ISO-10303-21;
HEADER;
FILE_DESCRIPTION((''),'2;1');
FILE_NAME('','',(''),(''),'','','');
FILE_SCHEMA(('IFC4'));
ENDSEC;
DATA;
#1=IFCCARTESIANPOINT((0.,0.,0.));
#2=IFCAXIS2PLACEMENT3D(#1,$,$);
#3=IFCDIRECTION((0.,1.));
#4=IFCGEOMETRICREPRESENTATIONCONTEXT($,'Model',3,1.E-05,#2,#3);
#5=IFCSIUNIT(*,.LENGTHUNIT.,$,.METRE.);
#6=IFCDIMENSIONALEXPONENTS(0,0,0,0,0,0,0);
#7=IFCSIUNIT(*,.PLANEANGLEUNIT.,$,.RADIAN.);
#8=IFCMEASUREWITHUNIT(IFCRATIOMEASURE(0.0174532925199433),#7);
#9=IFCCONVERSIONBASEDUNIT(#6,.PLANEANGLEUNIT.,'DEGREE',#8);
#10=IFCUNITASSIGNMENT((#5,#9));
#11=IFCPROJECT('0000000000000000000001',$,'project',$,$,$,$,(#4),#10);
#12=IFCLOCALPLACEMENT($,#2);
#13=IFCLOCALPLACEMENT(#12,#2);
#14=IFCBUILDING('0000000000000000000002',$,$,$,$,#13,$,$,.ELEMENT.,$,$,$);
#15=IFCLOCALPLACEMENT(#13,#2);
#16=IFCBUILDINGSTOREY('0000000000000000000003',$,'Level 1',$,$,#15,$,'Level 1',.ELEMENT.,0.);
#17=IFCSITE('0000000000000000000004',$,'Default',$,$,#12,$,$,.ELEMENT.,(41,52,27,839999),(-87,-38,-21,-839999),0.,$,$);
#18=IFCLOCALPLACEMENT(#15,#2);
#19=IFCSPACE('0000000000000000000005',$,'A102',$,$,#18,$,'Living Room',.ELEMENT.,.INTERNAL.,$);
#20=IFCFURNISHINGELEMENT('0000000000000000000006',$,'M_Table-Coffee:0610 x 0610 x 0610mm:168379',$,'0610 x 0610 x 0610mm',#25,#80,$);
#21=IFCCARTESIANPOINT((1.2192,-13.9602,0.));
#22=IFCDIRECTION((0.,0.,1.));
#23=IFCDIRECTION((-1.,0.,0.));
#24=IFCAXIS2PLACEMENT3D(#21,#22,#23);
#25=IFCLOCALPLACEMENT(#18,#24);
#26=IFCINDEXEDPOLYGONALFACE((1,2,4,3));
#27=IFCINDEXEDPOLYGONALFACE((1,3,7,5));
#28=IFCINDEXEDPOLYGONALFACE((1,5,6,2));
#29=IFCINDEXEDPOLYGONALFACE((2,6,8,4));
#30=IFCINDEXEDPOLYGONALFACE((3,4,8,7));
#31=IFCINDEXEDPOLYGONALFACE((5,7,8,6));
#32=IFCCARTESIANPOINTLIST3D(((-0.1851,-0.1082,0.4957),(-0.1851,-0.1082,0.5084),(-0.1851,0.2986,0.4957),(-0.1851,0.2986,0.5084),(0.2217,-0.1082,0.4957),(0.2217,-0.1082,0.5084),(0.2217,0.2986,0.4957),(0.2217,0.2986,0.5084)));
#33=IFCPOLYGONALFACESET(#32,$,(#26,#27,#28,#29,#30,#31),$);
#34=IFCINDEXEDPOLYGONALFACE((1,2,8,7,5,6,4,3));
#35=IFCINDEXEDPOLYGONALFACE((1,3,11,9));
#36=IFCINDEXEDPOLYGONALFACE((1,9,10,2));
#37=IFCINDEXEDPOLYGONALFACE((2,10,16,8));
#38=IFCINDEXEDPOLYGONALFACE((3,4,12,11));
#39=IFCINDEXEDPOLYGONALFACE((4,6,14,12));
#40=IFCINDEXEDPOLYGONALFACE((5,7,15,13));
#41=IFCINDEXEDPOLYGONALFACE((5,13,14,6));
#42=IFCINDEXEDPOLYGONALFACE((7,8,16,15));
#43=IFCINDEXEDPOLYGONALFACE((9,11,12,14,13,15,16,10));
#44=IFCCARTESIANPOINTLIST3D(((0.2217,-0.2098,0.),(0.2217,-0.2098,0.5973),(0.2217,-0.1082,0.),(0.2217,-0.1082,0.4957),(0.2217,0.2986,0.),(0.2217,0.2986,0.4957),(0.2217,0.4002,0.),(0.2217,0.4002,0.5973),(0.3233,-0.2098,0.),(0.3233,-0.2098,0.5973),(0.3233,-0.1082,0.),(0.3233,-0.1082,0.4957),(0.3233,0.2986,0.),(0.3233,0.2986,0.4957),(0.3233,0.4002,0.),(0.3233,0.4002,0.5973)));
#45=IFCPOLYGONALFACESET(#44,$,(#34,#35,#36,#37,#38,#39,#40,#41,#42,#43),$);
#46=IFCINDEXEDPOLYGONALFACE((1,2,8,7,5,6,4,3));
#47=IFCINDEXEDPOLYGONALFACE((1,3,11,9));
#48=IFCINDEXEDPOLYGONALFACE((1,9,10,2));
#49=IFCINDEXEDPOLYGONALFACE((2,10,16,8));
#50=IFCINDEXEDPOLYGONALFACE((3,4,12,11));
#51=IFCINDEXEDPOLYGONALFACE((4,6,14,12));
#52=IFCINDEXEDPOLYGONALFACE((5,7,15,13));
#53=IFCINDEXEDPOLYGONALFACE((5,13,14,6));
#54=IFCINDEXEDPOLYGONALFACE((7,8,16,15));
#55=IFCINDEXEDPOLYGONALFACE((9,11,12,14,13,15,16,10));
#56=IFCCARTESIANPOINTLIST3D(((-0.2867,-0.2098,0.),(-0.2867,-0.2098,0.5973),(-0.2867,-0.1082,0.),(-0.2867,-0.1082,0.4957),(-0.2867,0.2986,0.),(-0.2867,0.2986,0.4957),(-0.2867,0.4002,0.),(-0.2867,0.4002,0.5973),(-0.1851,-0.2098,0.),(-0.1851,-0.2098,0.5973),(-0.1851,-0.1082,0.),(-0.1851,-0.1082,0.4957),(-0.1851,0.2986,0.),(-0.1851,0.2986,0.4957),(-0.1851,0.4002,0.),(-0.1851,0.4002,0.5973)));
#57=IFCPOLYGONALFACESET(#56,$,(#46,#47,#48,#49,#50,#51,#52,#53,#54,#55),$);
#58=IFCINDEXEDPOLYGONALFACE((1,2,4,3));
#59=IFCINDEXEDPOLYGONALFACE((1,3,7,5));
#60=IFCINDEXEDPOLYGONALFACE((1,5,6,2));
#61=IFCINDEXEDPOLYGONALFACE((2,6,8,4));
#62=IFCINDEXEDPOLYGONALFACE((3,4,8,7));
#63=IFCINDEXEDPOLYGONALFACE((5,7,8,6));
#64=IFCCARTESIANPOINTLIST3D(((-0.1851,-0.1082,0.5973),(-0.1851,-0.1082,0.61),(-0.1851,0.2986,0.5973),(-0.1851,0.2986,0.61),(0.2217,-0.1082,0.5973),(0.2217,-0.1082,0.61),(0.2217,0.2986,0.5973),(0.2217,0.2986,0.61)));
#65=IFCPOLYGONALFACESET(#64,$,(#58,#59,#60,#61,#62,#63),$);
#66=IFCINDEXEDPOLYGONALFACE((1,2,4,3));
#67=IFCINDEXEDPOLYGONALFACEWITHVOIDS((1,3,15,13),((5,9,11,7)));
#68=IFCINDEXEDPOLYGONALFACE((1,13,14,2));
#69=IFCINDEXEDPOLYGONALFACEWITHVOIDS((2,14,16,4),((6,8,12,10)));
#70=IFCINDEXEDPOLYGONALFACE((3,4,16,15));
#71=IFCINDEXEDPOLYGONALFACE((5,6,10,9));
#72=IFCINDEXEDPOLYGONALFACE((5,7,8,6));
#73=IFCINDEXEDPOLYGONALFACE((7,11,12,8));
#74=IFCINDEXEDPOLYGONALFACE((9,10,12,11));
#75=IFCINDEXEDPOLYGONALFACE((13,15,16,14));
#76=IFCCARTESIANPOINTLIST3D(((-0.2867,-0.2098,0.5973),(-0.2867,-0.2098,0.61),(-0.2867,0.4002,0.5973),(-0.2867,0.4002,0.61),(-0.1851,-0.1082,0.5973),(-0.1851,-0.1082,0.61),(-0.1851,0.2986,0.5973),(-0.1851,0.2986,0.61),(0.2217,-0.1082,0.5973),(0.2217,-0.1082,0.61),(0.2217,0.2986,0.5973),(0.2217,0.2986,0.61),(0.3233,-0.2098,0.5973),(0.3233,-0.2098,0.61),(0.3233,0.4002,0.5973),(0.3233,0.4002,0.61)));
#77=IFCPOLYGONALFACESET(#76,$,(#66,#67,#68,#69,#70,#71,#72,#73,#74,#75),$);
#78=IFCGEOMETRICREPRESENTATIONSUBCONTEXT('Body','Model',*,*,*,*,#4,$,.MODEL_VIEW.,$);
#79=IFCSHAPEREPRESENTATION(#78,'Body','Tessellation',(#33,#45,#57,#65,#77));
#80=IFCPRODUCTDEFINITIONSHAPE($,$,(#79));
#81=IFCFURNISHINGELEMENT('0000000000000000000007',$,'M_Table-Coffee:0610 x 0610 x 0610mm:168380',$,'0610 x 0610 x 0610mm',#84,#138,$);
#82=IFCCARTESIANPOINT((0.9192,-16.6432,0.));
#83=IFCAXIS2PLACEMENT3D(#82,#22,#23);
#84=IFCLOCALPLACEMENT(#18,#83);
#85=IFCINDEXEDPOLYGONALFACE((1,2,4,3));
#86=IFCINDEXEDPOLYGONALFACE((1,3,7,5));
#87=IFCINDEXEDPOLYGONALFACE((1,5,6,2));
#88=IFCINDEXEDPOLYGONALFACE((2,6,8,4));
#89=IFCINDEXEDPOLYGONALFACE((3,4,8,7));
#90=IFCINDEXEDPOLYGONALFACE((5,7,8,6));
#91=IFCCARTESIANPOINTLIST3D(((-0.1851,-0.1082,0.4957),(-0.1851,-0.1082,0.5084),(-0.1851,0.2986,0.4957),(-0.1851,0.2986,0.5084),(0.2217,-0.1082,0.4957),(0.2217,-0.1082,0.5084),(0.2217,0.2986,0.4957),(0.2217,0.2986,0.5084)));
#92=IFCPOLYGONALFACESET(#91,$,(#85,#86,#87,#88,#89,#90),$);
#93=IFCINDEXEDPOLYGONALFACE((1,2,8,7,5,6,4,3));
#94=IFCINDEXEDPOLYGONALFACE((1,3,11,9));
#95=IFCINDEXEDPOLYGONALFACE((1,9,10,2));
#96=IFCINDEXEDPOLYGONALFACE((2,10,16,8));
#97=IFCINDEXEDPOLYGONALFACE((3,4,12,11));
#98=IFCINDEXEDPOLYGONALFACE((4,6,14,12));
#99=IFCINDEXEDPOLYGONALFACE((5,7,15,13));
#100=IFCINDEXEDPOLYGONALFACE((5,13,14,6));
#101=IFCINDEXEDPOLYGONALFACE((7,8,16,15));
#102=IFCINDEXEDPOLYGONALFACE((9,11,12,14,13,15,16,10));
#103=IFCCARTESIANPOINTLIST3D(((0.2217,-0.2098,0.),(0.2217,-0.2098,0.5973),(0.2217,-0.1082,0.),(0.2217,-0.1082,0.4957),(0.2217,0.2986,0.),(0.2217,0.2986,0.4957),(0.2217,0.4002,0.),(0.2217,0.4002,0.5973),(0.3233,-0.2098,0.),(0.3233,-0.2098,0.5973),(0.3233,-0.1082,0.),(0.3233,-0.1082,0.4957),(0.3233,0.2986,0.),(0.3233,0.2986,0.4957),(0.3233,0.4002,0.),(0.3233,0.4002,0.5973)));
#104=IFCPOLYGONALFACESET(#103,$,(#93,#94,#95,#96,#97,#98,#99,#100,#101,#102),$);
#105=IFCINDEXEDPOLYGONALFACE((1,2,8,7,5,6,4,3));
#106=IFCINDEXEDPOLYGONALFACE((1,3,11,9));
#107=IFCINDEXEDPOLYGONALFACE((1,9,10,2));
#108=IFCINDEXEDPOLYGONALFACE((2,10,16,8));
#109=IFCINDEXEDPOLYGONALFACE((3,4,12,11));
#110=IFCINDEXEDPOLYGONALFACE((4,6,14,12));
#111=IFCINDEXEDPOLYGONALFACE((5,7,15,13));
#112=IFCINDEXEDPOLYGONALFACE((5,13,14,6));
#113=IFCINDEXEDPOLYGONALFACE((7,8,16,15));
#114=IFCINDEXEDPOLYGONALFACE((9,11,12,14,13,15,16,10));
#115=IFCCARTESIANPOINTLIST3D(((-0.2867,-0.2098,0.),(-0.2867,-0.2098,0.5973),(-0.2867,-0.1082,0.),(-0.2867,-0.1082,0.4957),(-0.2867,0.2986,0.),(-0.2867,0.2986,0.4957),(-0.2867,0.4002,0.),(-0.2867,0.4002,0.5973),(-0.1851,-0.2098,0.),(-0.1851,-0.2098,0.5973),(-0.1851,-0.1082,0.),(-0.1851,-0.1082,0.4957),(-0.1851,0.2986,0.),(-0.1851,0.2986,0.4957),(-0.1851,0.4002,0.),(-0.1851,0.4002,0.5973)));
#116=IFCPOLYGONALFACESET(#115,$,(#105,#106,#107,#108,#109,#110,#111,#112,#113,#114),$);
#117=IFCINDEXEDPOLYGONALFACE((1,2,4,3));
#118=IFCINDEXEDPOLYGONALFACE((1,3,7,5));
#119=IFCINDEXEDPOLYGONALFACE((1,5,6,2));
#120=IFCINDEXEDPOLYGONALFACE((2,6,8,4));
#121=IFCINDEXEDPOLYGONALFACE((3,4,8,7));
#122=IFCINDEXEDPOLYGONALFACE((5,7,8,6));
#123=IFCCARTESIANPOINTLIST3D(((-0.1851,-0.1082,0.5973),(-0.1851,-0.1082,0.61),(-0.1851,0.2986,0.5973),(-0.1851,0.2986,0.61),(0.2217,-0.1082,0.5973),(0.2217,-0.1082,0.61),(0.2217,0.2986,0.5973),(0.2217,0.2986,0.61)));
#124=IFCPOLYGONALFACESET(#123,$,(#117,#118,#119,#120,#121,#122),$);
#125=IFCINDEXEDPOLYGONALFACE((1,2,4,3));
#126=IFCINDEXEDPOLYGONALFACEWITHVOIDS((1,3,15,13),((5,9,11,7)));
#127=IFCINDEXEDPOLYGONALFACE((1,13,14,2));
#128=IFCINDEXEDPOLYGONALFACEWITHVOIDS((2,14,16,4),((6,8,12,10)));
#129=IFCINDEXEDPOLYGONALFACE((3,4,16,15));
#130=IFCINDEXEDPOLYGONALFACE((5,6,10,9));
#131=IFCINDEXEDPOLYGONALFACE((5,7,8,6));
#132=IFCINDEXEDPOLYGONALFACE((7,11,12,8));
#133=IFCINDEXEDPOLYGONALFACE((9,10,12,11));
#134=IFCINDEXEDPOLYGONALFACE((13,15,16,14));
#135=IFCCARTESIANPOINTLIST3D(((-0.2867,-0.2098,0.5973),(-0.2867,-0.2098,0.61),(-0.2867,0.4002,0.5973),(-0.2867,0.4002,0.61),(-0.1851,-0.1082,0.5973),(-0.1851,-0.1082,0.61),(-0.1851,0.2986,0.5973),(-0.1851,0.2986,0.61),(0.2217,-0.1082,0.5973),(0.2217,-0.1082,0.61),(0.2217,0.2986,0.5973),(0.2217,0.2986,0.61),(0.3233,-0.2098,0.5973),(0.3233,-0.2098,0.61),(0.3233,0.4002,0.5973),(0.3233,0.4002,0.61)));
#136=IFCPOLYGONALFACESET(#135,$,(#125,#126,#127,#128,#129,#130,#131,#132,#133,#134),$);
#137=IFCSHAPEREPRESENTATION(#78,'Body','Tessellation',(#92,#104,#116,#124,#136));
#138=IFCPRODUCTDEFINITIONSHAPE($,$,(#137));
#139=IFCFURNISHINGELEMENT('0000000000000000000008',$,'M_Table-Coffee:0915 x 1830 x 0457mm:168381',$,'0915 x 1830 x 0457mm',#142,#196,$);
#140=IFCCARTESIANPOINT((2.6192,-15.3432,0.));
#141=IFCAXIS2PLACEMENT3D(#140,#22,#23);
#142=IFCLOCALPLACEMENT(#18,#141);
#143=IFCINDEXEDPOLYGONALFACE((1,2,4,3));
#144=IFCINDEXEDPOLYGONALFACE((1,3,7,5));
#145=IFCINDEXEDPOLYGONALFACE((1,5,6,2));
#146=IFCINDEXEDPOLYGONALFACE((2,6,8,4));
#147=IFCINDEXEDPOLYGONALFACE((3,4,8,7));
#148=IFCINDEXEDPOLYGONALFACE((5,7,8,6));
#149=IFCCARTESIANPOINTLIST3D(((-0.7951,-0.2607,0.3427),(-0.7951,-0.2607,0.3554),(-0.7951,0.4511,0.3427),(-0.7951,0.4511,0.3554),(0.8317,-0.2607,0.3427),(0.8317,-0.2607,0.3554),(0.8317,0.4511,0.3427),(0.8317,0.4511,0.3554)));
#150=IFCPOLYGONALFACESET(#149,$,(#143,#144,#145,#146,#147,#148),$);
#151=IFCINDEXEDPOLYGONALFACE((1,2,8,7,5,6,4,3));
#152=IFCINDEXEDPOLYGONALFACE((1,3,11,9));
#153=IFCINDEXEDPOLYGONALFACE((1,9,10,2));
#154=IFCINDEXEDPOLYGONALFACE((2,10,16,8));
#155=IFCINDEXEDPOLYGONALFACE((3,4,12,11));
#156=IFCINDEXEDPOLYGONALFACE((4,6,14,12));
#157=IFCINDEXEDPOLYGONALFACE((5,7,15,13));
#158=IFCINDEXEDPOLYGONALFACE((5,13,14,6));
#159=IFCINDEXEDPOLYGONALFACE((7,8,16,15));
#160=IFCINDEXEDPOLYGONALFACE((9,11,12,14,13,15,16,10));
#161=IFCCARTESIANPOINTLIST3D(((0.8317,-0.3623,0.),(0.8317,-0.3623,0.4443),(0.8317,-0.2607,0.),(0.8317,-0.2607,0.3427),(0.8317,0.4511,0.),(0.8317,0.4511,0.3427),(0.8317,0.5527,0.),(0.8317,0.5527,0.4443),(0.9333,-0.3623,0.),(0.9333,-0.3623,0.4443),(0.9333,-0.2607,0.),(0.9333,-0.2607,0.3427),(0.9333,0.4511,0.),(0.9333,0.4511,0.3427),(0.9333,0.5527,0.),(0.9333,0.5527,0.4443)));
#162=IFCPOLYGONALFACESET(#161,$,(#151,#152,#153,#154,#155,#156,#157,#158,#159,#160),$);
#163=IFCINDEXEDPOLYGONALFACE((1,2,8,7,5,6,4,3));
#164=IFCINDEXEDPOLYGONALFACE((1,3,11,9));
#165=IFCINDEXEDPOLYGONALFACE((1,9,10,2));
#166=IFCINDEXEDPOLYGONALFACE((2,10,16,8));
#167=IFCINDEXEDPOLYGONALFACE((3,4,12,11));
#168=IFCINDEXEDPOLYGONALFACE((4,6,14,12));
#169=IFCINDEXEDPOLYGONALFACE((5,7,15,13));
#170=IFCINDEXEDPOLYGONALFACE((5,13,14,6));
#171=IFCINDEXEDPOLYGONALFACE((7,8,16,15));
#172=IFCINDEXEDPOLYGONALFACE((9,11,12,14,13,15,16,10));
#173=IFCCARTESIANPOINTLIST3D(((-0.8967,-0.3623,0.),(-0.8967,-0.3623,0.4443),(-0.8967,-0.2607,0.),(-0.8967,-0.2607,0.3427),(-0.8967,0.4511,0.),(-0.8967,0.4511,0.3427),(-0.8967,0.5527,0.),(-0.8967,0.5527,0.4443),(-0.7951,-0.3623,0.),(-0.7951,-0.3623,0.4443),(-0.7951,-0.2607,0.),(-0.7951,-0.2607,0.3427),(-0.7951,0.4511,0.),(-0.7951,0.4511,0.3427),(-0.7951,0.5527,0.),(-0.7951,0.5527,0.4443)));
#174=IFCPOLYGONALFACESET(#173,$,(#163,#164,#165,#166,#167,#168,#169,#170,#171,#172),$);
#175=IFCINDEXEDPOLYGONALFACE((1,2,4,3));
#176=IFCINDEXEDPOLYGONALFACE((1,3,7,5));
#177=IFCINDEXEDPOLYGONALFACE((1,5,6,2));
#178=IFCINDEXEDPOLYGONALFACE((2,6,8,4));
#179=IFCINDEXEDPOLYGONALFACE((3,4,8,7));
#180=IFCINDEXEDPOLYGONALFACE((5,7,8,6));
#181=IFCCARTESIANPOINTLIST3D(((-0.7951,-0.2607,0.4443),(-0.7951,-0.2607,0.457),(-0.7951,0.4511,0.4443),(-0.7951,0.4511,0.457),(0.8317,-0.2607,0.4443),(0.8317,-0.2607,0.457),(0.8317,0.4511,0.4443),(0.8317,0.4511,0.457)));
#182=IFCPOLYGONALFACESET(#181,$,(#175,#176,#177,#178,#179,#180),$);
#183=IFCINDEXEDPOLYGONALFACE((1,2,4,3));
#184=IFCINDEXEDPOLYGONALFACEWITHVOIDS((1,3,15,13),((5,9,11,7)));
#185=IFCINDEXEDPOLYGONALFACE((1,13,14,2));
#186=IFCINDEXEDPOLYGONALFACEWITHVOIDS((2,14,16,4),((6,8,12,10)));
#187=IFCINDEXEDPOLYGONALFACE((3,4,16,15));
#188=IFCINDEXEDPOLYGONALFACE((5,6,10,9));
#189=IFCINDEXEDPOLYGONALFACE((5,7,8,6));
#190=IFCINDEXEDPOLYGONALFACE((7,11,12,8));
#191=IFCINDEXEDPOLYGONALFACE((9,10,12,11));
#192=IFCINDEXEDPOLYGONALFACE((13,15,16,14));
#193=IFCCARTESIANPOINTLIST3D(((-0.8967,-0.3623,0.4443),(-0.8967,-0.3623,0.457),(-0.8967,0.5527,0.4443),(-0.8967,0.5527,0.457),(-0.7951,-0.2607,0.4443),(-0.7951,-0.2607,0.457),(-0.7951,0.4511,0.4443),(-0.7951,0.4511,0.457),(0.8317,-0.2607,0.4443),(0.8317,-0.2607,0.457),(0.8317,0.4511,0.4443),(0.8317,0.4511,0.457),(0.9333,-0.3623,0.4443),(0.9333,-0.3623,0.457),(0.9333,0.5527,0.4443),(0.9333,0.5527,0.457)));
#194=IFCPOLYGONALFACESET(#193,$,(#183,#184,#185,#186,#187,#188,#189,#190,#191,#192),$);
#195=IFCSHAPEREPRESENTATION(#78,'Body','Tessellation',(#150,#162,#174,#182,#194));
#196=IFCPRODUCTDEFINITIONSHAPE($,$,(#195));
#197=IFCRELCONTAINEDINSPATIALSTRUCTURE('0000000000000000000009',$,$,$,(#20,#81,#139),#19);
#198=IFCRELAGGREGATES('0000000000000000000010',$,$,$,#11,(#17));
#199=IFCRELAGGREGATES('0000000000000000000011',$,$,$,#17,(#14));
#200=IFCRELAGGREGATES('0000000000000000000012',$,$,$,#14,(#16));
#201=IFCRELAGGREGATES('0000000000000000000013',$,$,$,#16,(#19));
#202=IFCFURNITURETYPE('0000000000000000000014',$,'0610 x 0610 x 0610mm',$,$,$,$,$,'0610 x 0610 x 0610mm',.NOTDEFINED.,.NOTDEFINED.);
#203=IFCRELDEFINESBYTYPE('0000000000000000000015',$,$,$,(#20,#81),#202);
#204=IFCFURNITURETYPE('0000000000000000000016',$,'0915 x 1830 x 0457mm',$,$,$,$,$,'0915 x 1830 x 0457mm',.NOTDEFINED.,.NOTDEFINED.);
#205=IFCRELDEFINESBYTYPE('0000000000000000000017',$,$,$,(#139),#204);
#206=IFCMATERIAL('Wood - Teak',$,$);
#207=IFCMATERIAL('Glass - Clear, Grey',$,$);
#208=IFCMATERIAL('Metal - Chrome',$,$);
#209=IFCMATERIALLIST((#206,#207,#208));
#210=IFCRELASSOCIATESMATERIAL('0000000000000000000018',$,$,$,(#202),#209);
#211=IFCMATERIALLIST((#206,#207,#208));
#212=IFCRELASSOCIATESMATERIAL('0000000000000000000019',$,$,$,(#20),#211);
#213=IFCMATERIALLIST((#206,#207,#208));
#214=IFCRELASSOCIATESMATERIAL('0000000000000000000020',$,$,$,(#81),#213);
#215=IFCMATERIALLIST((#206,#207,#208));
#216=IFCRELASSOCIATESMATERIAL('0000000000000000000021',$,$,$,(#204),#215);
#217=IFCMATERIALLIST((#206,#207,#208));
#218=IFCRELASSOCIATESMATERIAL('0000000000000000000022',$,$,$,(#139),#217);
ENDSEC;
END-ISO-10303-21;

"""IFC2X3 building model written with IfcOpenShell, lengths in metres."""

from ifc_helpers import new_model, entity, si_unit, converted_unit, direction, frame, origin, origin_2d_with_axis, place, context, subcontext, project, spatial, polyline, rectangle, outline, extrude, source, transform, mapped, material, material_list, type_object, type_shapes, element, save


model = new_model("IFC2X3")

# Units and contexts
model_context = context("Model", 3, precision=1e-05, world=origin(), true_north=direction((0.0, 1.0)))
body_context = subcontext(model_context, "Body", "Model", "MODEL_VIEW")
ifc_project = project(units=[si_unit("LENGTHUNIT", "METRE"), converted_unit("PLANEANGLEUNIT", "DEGREE", entity("IfcRatioMeasure", 0.0174532925199433), si_unit("PLANEANGLEUNIT", "RADIAN"), dimensions=[0, 0, 0, 0, 0, 0, 0])], contexts=[model_context])

# Site, building, storey
site_placement = place(None, origin())
site = spatial("IfcSite", under=ifc_project, at=site_placement, Name="Default", CompositionType="ELEMENT", RefLatitude=(41, 52, 27, 839999), RefLongitude=(-87, -38, -21, -839999), RefElevation=0.0)
building_placement = place(site_placement, origin())
building = spatial("IfcBuilding", under=site, at=building_placement, CompositionType="ELEMENT")
storey_placement = place(building_placement, origin())
storey = spatial("IfcBuildingStorey", under=building, at=storey_placement, Name="Level 1", LongName="Level 1", CompositionType="ELEMENT", Elevation=0.0)

# Shared definitions
space_1_placement = place(storey_placement, origin())
space_1 = spatial("IfcSpace", under=storey, at=space_1_placement, Name="A102", LongName="Living Room", CompositionType="ELEMENT", InteriorOrExteriorSpace="INTERNAL")

# Furnishing elements
ifc_material_1 = material(Name="Wood - Teak")
ifc_material_2 = material(Name="Glass - Clear, Grey")
ifc_material_3 = material(Name="Metal - Chrome")
ifc_material_list_1 = material_list([ifc_material_1, ifc_material_2, ifc_material_3])
ifc_material_list_2 = material_list([ifc_material_1, ifc_material_2, ifc_material_3])
furniture_type_1 = type_object("IfcFurnitureType", Name="0610 x 0610 x 0610mm", ElementType="0610 x 0610 x 0610mm", material=ifc_material_list_2)
shared_shape_1 = source(origin(), body_context, "Body", "SweptSolid", [
    extrude(rectangle(XDim=0.4068, YDim=0.4068, at=origin_2d_with_axis()), frame((0.0183, 0.0952, 0.4957), z_axis=(0.0, 0.0, 1.0), x_axis=(-1.0, 0.0, 0.0)), (0.0, 0.0, 1.0), 0.0127),
    extrude(outline(polyline([(-0.2732, -0.305), (0.324, -0.305), (0.324, 0.305), (-0.2732, 0.305), (-0.2732, 0.2034), (0.2225, 0.2034), (0.2225, -0.2034), (-0.2732, -0.2034), (-0.2732, -0.305)])), frame((0.2217, 0.0952, 0.2732), z_axis=(1.0, 0.0, 0.0), x_axis=(0.0, 0.0, 1.0)), (0.0, 0.0, 1.0), 0.1016),
    extrude(outline(polyline([(-0.305, -0.3241), (0.305, -0.3241), (0.305, 0.2733), (0.2034, 0.2733), (0.2034, -0.2224), (-0.2034, -0.2224), (-0.2034, 0.2733), (-0.305, 0.2733), (-0.305, -0.3241)])), frame((-0.2867, 0.0952, 0.2733), z_axis=(1.0, 0.0, 0.0), x_axis=(0.0, -1.0, 0.0)), (0.0, 0.0, 1.0), 0.1016),
    extrude(rectangle(XDim=0.4068, YDim=0.4068, at=origin_2d_with_axis()), frame((0.0183, 0.0952, 0.5973), z_axis=(0.0, 0.0, 1.0), x_axis=(-1.0, 0.0, 0.0)), (0.0, 0.0, 1.0), 0.0127),
    extrude(outline(polyline([(-0.305, -0.305), (0.305, -0.305), (0.305, 0.305), (-0.305, 0.305), (-0.305, -0.305)]), holes=[polyline([(-0.2034, -0.2034), (-0.2034, 0.2034), (0.2034, 0.2034), (0.2034, -0.2034), (-0.2034, -0.2034)])]), frame((0.0183, 0.0952, 0.5973), z_axis=(0.0, 0.0, 1.0), x_axis=(-1.0, 0.0, 0.0)), (0.0, 0.0, 1.0), 0.0127),
])
type_shapes(furniture_type_1, [shared_shape_1])
furnishing_1_placement = place(space_1_placement, frame((1.2192, -13.9602, 0.0), z_axis=(0.0, 0.0, 1.0), x_axis=(-1.0, 0.0, 0.0)))
element("IfcFurnishingElement", 1, at=furnishing_1_placement, inside=space_1, type_object=furniture_type_1, material=ifc_material_list_1, Name="M_Table-Coffee:0610 x 0610 x 0610mm:168379", ObjectType="0610 x 0610 x 0610mm", context=body_context, shape_type="MappedRepresentation", body=[
    mapped(shared_shape_1, transform((0.0, 0.0, 0.0), scale=1.0)),
])
ifc_material_list_3 = material_list([ifc_material_1, ifc_material_2, ifc_material_3])
furnishing_2_placement = place(space_1_placement, frame((0.9192, -16.6432, 0.0), z_axis=(0.0, 0.0, 1.0), x_axis=(-1.0, 0.0, 0.0)))
element("IfcFurnishingElement", 2, at=furnishing_2_placement, inside=space_1, type_object=furniture_type_1, material=ifc_material_list_3, Name="M_Table-Coffee:0610 x 0610 x 0610mm:168380", ObjectType="0610 x 0610 x 0610mm", context=body_context, shape_type="MappedRepresentation", body=[
    mapped(shared_shape_1, transform((0.0, 0.0, 0.0), scale=1.0)),
])
ifc_material_list_4 = material_list([ifc_material_1, ifc_material_2, ifc_material_3])
ifc_material_list_5 = material_list([ifc_material_1, ifc_material_2, ifc_material_3])
furniture_type_2 = type_object("IfcFurnitureType", Name="0915 x 1830 x 0457mm", ElementType="0915 x 1830 x 0457mm", material=ifc_material_list_5)
shared_shape_2 = source(origin(), body_context, "Body", "SweptSolid", [
    extrude(rectangle(XDim=1.6268, YDim=0.7118, at=origin_2d_with_axis()), frame((0.0183, 0.0952, 0.3427), z_axis=(0.0, 0.0, 1.0), x_axis=(-1.0, 0.0, 0.0)), (0.0, 0.0, 1.0), 0.0127),
    extrude(outline(polyline([(-0.1967, -0.4575), (0.2475, -0.4575), (0.2475, 0.4575), (-0.1967, 0.4575), (-0.1967, 0.3559), (0.146, 0.3559), (0.146, -0.3559), (-0.1967, -0.3559), (-0.1967, -0.4575)])), frame((0.8317, 0.0952, 0.1967), z_axis=(1.0, 0.0, 0.0), x_axis=(0.0, 0.0, 1.0)), (0.0, 0.0, 1.0), 0.1016),
    extrude(outline(polyline([(-0.4575, -0.2476), (0.4575, -0.2476), (0.4575, 0.1968), (0.3559, 0.1968), (0.3559, -0.1459), (-0.3559, -0.1459), (-0.3559, 0.1968), (-0.4575, 0.1968), (-0.4575, -0.2476)])), frame((-0.8967, 0.0952, 0.1968), z_axis=(1.0, 0.0, 0.0), x_axis=(0.0, -1.0, 0.0)), (0.0, 0.0, 1.0), 0.1016),
    extrude(rectangle(XDim=1.6268, YDim=0.7118, at=origin_2d_with_axis()), frame((0.0183, 0.0952, 0.4443), z_axis=(0.0, 0.0, 1.0), x_axis=(-1.0, 0.0, 0.0)), (0.0, 0.0, 1.0), 0.0127),
    extrude(outline(polyline([(-0.915, -0.4575), (0.915, -0.4575), (0.915, 0.4575), (-0.915, 0.4575), (-0.915, -0.4575)]), holes=[polyline([(-0.8134, -0.3559), (-0.8134, 0.3559), (0.8134, 0.3559), (0.8134, -0.3559), (-0.8134, -0.3559)])]), frame((0.0183, 0.0952, 0.4443), z_axis=(0.0, 0.0, 1.0), x_axis=(-1.0, 0.0, 0.0)), (0.0, 0.0, 1.0), 0.0127),
])
type_shapes(furniture_type_2, [shared_shape_2])
furnishing_3_placement = place(space_1_placement, frame((2.6192, -15.3432, 0.0), z_axis=(0.0, 0.0, 1.0), x_axis=(-1.0, 0.0, 0.0)))
element("IfcFurnishingElement", 3, at=furnishing_3_placement, inside=space_1, type_object=furniture_type_2, material=ifc_material_list_4, Name="M_Table-Coffee:0915 x 1830 x 0457mm:168381", ObjectType="0915 x 1830 x 0457mm", context=body_context, shape_type="MappedRepresentation", body=[
    mapped(shared_shape_2, transform((0.0, 0.0, 0.0), scale=1.0)),
])

save(model, "model.ifc")
